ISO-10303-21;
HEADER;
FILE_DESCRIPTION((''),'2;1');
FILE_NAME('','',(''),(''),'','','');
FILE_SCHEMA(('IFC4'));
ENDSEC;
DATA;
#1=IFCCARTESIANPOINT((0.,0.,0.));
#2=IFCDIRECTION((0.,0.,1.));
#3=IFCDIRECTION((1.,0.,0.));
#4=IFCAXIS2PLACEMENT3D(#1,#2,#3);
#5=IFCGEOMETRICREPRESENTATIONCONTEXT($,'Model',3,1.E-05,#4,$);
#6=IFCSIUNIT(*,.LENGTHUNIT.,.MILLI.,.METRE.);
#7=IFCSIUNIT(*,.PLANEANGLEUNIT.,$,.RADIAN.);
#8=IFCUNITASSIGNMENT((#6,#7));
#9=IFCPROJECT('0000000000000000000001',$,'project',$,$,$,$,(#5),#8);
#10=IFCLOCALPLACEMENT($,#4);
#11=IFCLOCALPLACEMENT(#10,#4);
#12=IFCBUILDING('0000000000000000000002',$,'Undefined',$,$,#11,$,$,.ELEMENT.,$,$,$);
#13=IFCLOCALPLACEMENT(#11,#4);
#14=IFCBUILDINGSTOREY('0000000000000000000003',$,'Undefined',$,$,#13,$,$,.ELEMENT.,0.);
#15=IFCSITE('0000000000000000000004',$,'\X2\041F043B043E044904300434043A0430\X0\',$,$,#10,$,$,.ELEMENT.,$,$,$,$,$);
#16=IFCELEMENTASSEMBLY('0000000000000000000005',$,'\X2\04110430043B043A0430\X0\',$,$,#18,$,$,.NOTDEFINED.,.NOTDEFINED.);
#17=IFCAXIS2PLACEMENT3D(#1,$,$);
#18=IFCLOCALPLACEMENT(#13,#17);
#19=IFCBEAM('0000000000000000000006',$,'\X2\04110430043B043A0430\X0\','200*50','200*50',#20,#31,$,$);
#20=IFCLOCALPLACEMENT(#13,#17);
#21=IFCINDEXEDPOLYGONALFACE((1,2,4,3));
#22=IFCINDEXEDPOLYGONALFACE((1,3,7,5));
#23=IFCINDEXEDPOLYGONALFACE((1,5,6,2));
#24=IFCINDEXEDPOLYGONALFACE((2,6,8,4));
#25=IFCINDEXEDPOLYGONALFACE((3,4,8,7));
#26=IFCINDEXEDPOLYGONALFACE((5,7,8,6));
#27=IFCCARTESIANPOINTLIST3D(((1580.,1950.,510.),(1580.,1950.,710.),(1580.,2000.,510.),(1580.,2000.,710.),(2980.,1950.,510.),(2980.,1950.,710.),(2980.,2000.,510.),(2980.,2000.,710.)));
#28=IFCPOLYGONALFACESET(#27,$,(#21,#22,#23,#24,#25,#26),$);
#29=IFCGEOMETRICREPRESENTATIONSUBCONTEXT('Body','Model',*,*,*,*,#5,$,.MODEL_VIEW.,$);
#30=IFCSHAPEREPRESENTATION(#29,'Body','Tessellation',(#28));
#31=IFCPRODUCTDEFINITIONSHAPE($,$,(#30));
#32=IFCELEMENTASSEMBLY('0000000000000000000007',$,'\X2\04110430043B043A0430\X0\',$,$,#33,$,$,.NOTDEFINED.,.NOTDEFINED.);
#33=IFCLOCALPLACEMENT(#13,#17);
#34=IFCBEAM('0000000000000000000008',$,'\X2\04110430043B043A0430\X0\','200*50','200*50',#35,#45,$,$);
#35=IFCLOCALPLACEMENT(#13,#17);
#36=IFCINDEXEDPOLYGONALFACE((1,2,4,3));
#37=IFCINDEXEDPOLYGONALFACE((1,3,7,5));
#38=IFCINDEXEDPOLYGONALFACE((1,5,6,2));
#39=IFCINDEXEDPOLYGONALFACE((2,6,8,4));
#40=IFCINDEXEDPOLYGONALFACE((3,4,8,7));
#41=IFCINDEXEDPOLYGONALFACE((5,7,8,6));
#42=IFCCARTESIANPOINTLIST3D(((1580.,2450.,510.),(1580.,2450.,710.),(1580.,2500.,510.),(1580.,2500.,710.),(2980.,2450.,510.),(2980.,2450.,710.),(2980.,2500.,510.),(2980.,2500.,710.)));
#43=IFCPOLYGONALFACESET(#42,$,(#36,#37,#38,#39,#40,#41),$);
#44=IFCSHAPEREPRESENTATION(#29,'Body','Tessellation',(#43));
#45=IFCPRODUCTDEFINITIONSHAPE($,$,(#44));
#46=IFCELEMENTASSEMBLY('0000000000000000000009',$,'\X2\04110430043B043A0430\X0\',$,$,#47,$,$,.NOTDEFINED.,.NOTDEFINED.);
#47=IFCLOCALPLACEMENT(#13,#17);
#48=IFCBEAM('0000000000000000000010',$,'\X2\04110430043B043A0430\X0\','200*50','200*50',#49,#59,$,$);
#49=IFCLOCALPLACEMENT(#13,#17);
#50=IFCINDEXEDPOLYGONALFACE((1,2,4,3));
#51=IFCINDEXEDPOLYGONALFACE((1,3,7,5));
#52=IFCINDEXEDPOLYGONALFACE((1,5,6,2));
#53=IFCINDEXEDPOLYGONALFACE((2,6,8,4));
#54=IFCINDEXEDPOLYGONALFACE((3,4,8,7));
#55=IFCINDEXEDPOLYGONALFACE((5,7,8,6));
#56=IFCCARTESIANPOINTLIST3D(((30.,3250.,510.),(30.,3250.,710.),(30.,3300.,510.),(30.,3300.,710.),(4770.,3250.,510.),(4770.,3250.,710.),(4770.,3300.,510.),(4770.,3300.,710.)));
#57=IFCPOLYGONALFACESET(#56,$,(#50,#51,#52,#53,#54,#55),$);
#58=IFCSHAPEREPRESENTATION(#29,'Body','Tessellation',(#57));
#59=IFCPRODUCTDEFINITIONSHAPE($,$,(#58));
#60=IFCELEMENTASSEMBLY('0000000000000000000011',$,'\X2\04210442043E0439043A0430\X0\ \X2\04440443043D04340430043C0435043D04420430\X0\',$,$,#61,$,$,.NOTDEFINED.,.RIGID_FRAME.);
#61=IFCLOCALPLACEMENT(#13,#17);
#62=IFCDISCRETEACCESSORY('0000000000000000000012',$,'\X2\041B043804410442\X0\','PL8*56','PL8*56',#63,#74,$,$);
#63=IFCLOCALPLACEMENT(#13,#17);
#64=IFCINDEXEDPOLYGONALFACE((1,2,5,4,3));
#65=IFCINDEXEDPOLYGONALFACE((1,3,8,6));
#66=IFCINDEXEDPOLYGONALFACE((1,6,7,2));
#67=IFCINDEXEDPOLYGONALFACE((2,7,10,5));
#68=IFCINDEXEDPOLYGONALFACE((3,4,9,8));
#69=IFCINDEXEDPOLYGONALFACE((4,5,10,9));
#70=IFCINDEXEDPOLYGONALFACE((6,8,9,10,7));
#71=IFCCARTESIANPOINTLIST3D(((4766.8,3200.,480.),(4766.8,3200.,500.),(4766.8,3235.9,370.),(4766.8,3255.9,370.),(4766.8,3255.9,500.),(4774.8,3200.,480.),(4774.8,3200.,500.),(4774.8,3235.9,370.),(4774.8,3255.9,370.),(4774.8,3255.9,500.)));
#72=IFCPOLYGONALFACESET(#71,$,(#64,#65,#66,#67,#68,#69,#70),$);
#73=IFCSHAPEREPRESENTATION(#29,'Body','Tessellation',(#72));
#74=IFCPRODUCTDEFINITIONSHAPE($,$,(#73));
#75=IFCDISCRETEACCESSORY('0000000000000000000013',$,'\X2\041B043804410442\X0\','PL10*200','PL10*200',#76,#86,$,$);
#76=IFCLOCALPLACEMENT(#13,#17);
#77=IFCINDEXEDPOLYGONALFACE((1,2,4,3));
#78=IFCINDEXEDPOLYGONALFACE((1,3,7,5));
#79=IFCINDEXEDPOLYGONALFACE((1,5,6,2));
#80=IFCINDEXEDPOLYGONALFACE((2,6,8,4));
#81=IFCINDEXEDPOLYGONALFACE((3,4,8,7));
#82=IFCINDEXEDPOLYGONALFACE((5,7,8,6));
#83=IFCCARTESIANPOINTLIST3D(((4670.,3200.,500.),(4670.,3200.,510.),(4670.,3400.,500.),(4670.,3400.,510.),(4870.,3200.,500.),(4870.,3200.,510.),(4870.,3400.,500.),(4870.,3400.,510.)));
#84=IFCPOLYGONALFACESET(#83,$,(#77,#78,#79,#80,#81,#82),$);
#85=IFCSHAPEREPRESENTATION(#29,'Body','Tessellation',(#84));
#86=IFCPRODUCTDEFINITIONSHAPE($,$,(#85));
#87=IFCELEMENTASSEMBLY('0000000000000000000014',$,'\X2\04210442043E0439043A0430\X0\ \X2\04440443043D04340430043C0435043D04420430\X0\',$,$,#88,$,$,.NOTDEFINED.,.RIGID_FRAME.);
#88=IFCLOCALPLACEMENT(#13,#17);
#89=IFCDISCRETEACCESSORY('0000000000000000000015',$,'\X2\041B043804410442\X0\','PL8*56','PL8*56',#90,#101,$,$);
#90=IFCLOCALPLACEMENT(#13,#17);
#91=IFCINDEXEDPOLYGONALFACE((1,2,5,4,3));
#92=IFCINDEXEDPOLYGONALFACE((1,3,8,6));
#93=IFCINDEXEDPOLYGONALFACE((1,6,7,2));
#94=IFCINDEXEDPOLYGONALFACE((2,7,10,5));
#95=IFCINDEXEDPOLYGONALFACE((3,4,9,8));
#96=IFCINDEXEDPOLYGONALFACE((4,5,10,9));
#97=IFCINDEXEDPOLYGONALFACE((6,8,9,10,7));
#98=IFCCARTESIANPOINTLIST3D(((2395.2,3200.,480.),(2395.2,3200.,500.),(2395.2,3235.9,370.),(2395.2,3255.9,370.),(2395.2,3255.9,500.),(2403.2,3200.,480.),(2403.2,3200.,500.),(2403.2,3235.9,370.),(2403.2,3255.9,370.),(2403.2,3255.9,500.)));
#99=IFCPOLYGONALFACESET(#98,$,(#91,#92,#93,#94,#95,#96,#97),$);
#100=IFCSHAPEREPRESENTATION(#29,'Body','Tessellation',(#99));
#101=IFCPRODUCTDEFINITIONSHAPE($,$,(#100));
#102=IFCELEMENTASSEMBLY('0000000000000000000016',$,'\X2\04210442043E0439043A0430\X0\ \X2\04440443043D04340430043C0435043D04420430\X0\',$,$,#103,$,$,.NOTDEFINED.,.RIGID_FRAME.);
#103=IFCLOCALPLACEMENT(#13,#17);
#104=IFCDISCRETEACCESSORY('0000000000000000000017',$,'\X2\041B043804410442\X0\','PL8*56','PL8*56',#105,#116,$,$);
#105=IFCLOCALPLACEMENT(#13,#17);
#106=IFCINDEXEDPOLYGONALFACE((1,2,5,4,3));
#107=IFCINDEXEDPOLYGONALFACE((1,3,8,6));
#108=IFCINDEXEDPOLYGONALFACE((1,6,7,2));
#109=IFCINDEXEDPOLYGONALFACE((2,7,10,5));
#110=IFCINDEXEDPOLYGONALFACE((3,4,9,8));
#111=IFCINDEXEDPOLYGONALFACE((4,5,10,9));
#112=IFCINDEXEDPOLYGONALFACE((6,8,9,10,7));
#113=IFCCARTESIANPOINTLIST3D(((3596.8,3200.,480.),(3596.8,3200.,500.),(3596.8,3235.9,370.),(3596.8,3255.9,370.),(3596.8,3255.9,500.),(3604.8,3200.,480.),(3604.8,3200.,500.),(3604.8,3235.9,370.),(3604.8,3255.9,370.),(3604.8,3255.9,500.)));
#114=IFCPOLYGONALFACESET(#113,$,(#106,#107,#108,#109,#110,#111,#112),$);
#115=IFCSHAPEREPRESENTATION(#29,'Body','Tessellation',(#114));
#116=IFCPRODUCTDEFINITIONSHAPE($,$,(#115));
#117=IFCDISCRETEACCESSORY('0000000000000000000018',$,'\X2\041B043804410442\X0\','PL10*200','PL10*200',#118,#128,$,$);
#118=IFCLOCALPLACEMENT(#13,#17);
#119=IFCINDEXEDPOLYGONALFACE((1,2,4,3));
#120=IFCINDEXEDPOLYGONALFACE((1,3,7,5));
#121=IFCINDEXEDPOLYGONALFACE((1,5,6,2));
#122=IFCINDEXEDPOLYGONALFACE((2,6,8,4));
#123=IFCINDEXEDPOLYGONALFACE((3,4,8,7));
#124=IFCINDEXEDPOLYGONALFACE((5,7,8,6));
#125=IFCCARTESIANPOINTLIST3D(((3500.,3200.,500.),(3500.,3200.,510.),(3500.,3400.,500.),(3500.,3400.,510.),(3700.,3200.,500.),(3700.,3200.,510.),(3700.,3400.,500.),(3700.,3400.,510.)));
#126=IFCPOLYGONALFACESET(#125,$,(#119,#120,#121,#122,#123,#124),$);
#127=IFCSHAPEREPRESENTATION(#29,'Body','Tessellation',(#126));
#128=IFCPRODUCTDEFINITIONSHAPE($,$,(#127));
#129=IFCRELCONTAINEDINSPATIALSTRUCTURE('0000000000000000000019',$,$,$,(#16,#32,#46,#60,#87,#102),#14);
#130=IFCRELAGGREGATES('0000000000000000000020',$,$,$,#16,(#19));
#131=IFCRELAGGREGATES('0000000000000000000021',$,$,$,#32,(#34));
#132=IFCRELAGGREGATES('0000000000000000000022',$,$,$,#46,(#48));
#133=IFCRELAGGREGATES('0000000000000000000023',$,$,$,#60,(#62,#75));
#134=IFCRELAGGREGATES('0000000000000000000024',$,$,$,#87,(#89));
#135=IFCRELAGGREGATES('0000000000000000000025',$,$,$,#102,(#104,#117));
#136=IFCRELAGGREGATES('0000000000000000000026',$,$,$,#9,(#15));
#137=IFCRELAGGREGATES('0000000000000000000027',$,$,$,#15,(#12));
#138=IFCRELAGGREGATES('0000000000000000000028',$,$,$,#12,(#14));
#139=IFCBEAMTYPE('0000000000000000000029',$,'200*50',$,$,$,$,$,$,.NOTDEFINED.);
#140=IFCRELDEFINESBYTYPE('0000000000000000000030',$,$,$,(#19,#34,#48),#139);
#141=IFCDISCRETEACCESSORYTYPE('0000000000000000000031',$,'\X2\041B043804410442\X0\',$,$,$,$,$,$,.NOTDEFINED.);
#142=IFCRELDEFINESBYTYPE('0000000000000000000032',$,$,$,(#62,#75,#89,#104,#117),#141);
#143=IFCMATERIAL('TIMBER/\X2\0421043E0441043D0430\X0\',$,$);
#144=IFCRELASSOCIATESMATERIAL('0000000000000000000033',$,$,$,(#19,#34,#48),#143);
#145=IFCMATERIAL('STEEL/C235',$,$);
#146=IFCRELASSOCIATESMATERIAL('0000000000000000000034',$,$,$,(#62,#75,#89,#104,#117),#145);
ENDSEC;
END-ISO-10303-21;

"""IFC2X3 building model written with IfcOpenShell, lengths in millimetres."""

from ifc_helpers import new_model, si_unit, frame, origin_with_axes, origin_2d_with_axis, place, context, subcontext, project, spatial, polyline, rectangle, outline, extrude, material, type_object, element, aggregate, save


model = new_model("IFC2X3")

# Units and contexts
model_context = context("Model", 3, precision=1e-05, world=origin_with_axes())
body_context = subcontext(model_context, "Body", "Model", "MODEL_VIEW")
ifc_project = project(units=[si_unit("LENGTHUNIT", "METRE", prefix="MILLI"), si_unit("PLANEANGLEUNIT", "RADIAN")], contexts=[model_context])

# Site, building, storey
site_placement = place(None, origin_with_axes())
site = spatial("IfcSite", under=ifc_project, at=site_placement, Name="Площадка", CompositionType="ELEMENT")
building_placement = place(site_placement, origin_with_axes())
building = spatial("IfcBuilding", under=site, at=building_placement, Name="Undefined", CompositionType="ELEMENT")
storey_placement = place(building_placement, origin_with_axes())
storey = spatial("IfcBuildingStorey", under=building, at=storey_placement, Name="Undefined", CompositionType="ELEMENT", Elevation=0.0)

# Shared definitions
ifc_material_1 = material(Name="TIMBER/Сосна")

# Element assemblies, beams
beam_type = type_object("IfcBeamType", Name="200*50", PredefinedType="NOTDEFINED")
assembly_1_placement = place(storey_placement, origin_with_axes())
assembly_1 = element("IfcElementAssembly", 1, at=assembly_1_placement, inside=storey, Name="Балка", AssemblyPlace="NOTDEFINED", PredefinedType="NOTDEFINED")
beam_1_placement = place(assembly_1_placement, frame((2980.0, 1975.0, 610.0), z_axis=(0.0, 0.0, -1.0), x_axis=(-1.0, 0.0, 0.0)))
beam_1 = element("IfcBeam", 2, at=beam_1_placement, type_object=beam_type, material=ifc_material_1, Name="Балка", Description="200*50", ObjectType="200*50", context=body_context, shape_type="SweptSolid", body=[
    extrude(rectangle(XDim=50.0, YDim=200.0, at=origin_2d_with_axis()), frame((1400.0, 0.0, 0.0), z_axis=(-1.0, 0.0, 0.0), x_axis=(0.0, -1.0, 0.0)), (0.0, 0.0, 1.0), 1400.0),
])
aggregate(assembly_1, [beam_1])
assembly_2_placement = place(storey_placement, origin_with_axes())
assembly_2 = element("IfcElementAssembly", 3, at=assembly_2_placement, inside=storey, Name="Балка", AssemblyPlace="NOTDEFINED", PredefinedType="NOTDEFINED")
beam_2_placement = place(assembly_2_placement, frame((2980.0, 2475.0, 610.0), z_axis=(0.0, 0.0, -1.0), x_axis=(-1.0, 0.0, 0.0)))
beam_2 = element("IfcBeam", 4, at=beam_2_placement, type_object=beam_type, material=ifc_material_1, Name="Балка", Description="200*50", ObjectType="200*50", context=body_context, shape_type="SweptSolid", body=[
    extrude(rectangle(XDim=50.0, YDim=200.0, at=origin_2d_with_axis()), frame((1400.0, 0.0, 0.0), z_axis=(-1.0, 0.0, 0.0), x_axis=(0.0, -1.0, 0.0)), (0.0, 0.0, 1.0), 1400.0),
])
aggregate(assembly_2, [beam_2])
assembly_3_placement = place(storey_placement, origin_with_axes())
assembly_3 = element("IfcElementAssembly", 5, at=assembly_3_placement, inside=storey, Name="Балка", AssemblyPlace="NOTDEFINED", PredefinedType="NOTDEFINED")
beam_3_placement = place(assembly_3_placement, frame((4770.0, 3275.0, 610.0), z_axis=(0.0, 0.0, -1.0), x_axis=(-1.0, 0.0, 0.0)))
beam_3 = element("IfcBeam", 6, at=beam_3_placement, type_object=beam_type, material=ifc_material_1, Name="Балка", Description="200*50", ObjectType="200*50", context=body_context, shape_type="SweptSolid", body=[
    extrude(rectangle(XDim=50.0, YDim=200.0, at=origin_2d_with_axis()), frame((4740.0, 0.0, 0.0), z_axis=(-1.0, 0.0, 0.0), x_axis=(0.0, -1.0, 0.0)), (0.0, 0.0, 1.0), 4740.0),
])
aggregate(assembly_3, [beam_3])

# Element assembly, discrete accessories
assembly_4_placement = place(storey_placement, origin_with_axes())
assembly_4 = element("IfcElementAssembly", 7, at=assembly_4_placement, inside=storey, Name="Стойка фундамента", AssemblyPlace="NOTDEFINED", PredefinedType="RIGID_FRAME")
ifc_material_2 = material(Name="STEEL/C235")
discrete_accessory_type = type_object("IfcDiscreteAccessoryType", Name="Лист")
discrete_accessory_1_placement = place(assembly_4_placement, frame((4770.8, 3255.9, 500.0), z_axis=(1.0, 0.0, 0.0), x_axis=(0.0, -1.0, 0.0)))
discrete_accessory_1 = element("IfcDiscreteAccessory", 8, at=discrete_accessory_1_placement, type_object=discrete_accessory_type, material=ifc_material_2, Name="Лист", Description="PL8*56", ObjectType="PL8*56", context=body_context, shape_type="SweptSolid", body=[
    extrude(outline(polyline([(0.0, 0.0), (55.9, 0.0), (55.9, 20.0), (20.0, 130.0), (0.0, 130.0), (0.0, 0.0)])), frame((0.0, 0.0, -4.0), z_axis=(0.0, 0.0, 1.0), x_axis=(1.0, 0.0, 0.0)), (0.0, 0.0, 1.0), 8.0),
])
discrete_accessory_2_placement = place(assembly_4_placement, frame((4870.0, 3200.0, 505.0), z_axis=(0.0, 0.0, 1.0), x_axis=(0.0, 1.0, 0.0)))
discrete_accessory_2 = element("IfcDiscreteAccessory", 9, at=discrete_accessory_2_placement, type_object=discrete_accessory_type, material=ifc_material_2, Name="Лист", Description="PL10*200", ObjectType="PL10*200", context=body_context, shape_type="SweptSolid", body=[
    extrude(outline(polyline([(0.0, 0.0), (200.0, 0.0), (200.0, 200.0), (0.0, 200.0), (0.0, 0.0)])), frame((0.0, 0.0, -5.0), z_axis=(0.0, 0.0, 1.0), x_axis=(1.0, 0.0, 0.0)), (0.0, 0.0, 1.0), 10.0),
])
aggregate(assembly_4, [discrete_accessory_1, discrete_accessory_2])

# Element assembly, discrete accessory
assembly_5_placement = place(storey_placement, origin_with_axes())
assembly_5 = element("IfcElementAssembly", 10, at=assembly_5_placement, inside=storey, Name="Стойка фундамента", AssemblyPlace="NOTDEFINED", PredefinedType="RIGID_FRAME")
discrete_accessory_3_placement = place(assembly_5_placement, frame((2399.2, 3255.9, 500.0), z_axis=(1.0, 0.0, 0.0), x_axis=(0.0, -1.0, 0.0)))
discrete_accessory_3 = element("IfcDiscreteAccessory", 11, at=discrete_accessory_3_placement, type_object=discrete_accessory_type, material=ifc_material_2, Name="Лист", Description="PL8*56", ObjectType="PL8*56", context=body_context, shape_type="SweptSolid", body=[
    extrude(outline(polyline([(0.0, 0.0), (55.9, 0.0), (55.9, 20.0), (20.0, 130.0), (0.0, 130.0), (0.0, 0.0)])), frame((0.0, 0.0, -4.0), z_axis=(0.0, 0.0, 1.0), x_axis=(1.0, 0.0, 0.0)), (0.0, 0.0, 1.0), 8.0),
])
aggregate(assembly_5, [discrete_accessory_3])

# Element assembly, discrete accessories
assembly_6_placement = place(storey_placement, origin_with_axes())
assembly_6 = element("IfcElementAssembly", 12, at=assembly_6_placement, inside=storey, Name="Стойка фундамента", AssemblyPlace="NOTDEFINED", PredefinedType="RIGID_FRAME")
discrete_accessory_4_placement = place(assembly_6_placement, frame((3600.8, 3255.9, 500.0), z_axis=(1.0, 0.0, 0.0), x_axis=(0.0, -1.0, 0.0)))
discrete_accessory_4 = element("IfcDiscreteAccessory", 13, at=discrete_accessory_4_placement, type_object=discrete_accessory_type, material=ifc_material_2, Name="Лист", Description="PL8*56", ObjectType="PL8*56", context=body_context, shape_type="SweptSolid", body=[
    extrude(outline(polyline([(0.0, 0.0), (55.9, 0.0), (55.9, 20.0), (20.0, 130.0), (0.0, 130.0), (0.0, 0.0)])), frame((0.0, 0.0, -4.0), z_axis=(0.0, 0.0, 1.0), x_axis=(1.0, 0.0, 0.0)), (0.0, 0.0, 1.0), 8.0),
])
discrete_accessory_5_placement = place(assembly_6_placement, frame((3700.0, 3200.0, 505.0), z_axis=(0.0, 0.0, 1.0), x_axis=(0.0, 1.0, 0.0)))
discrete_accessory_5 = element("IfcDiscreteAccessory", 14, at=discrete_accessory_5_placement, type_object=discrete_accessory_type, material=ifc_material_2, Name="Лист", Description="PL10*200", ObjectType="PL10*200", context=body_context, shape_type="SweptSolid", body=[
    extrude(outline(polyline([(0.0, 0.0), (200.0, 0.0), (200.0, 200.0), (0.0, 200.0), (0.0, 0.0)])), frame((0.0, 0.0, -5.0), z_axis=(0.0, 0.0, 1.0), x_axis=(1.0, 0.0, 0.0)), (0.0, 0.0, 1.0), 10.0),
])
aggregate(assembly_6, [discrete_accessory_4, discrete_accessory_5])

save(model, "model.ifc")
